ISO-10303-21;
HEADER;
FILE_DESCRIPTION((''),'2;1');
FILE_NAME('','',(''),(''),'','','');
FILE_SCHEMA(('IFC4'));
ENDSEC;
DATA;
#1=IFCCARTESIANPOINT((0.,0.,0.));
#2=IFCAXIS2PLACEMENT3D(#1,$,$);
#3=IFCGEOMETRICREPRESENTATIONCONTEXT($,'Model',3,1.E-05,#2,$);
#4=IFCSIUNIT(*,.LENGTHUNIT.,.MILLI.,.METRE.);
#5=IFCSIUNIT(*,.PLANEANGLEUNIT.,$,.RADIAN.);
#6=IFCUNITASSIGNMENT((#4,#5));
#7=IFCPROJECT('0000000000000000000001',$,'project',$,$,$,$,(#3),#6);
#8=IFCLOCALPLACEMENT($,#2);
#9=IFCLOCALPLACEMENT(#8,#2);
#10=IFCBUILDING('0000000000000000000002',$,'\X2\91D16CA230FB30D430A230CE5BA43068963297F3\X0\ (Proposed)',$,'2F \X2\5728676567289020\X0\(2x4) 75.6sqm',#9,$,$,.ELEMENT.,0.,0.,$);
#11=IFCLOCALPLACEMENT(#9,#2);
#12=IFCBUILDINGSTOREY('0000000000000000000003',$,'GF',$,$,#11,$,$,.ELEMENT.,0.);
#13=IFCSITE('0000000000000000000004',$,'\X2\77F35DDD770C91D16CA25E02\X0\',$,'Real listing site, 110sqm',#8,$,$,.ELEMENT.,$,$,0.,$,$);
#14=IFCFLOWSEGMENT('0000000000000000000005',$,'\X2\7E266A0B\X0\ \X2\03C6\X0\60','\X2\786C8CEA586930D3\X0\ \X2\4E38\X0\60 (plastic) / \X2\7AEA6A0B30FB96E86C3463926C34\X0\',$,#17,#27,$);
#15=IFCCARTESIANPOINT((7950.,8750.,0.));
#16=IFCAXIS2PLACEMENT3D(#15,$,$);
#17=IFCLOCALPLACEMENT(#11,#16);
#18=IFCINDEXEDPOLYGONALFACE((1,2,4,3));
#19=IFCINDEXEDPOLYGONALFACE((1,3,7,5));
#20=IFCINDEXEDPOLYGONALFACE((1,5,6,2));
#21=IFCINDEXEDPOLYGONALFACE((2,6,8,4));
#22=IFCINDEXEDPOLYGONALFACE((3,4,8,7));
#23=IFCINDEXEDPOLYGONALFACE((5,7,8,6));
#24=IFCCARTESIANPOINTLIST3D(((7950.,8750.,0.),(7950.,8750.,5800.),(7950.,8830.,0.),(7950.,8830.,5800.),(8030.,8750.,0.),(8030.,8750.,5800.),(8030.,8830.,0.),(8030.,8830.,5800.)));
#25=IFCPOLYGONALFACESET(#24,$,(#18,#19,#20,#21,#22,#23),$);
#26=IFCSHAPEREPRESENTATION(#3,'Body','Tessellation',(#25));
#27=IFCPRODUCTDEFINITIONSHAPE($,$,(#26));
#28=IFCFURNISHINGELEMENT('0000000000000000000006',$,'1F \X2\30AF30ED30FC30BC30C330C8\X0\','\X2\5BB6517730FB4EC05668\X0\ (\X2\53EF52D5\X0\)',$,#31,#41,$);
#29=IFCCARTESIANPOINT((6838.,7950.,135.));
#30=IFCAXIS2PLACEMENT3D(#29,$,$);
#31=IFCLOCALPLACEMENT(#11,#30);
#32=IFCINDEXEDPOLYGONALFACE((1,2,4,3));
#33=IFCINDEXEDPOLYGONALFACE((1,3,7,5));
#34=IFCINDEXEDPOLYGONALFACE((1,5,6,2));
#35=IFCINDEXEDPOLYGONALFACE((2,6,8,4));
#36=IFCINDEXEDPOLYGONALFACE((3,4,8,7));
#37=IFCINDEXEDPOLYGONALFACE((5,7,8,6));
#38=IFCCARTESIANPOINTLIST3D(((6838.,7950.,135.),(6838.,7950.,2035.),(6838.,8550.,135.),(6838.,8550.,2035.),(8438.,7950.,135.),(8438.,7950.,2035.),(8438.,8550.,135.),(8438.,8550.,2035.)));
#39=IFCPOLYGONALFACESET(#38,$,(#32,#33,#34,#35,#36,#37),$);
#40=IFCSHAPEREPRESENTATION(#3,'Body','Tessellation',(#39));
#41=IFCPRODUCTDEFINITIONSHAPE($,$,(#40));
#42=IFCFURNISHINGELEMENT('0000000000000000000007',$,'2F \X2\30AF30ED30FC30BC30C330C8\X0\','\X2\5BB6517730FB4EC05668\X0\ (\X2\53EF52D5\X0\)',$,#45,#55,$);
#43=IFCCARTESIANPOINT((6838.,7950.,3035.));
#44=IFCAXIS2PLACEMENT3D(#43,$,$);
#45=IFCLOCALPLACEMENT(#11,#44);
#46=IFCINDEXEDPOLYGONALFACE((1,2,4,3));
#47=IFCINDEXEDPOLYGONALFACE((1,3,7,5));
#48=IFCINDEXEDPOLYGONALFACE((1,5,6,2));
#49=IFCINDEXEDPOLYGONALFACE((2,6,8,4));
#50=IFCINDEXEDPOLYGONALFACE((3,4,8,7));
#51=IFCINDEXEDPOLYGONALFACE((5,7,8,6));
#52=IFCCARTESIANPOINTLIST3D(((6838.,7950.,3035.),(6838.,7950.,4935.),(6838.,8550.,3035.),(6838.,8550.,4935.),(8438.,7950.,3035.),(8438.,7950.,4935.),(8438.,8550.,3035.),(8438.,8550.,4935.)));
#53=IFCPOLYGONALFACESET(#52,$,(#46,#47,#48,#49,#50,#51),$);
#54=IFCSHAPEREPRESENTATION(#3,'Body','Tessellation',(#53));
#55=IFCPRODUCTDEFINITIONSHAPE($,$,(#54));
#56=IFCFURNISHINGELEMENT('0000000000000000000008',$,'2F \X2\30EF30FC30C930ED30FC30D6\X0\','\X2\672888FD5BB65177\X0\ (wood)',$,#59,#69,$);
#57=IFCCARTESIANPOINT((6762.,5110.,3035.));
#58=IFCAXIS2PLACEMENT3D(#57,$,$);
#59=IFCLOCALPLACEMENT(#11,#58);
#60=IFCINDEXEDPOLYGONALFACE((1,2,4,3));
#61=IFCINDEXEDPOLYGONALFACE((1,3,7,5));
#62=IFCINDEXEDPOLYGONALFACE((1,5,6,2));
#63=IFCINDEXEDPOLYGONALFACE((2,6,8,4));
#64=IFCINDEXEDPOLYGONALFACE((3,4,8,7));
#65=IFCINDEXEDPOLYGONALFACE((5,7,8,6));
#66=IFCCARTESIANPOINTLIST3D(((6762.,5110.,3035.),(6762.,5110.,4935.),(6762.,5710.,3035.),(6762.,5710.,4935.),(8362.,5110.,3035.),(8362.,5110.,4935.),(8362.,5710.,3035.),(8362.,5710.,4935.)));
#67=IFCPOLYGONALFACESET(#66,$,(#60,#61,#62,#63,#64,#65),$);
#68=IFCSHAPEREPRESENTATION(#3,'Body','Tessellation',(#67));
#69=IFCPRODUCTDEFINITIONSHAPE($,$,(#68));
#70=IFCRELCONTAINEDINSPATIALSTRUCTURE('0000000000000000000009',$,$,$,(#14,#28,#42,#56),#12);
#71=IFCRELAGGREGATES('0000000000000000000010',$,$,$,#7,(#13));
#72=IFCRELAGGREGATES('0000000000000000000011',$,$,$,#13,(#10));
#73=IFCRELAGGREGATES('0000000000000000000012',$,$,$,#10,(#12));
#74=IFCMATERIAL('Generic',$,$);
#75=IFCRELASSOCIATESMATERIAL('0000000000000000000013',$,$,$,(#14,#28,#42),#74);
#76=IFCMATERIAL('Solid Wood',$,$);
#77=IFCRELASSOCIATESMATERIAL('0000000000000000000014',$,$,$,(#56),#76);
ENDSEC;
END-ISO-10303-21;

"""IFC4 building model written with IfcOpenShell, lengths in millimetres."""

from ifc_helpers import new_model, si_unit, frame, frame_2d, origin, place, context, project, spatial, rectangle, extrude, material, element, save


model = new_model("IFC4")

# Units and contexts
model_context = context("Model", 3, precision=1e-05, world=origin())
ifc_project = project(units=[si_unit("LENGTHUNIT", "METRE", prefix="MILLI"), si_unit("PLANEANGLEUNIT", "RADIAN")], contexts=[model_context])

# Site, building, storey
site_placement = place(None, origin())
site = spatial("IfcSite", under=ifc_project, at=site_placement, Name="石川県金沢市", ObjectType="Real listing site, 110sqm", CompositionType="ELEMENT", RefElevation=0.0)
building_placement = place(site_placement, origin())
building = spatial("IfcBuilding", under=site, at=building_placement, Name="金沢・ピアノ室と防音 (Proposed)", ObjectType="2F 在来木造(2x4) 75.6sqm", CompositionType="ELEMENT", ElevationOfRefHeight=0.0, ElevationOfTerrain=0.0)
storey_placement = place(building_placement, origin())
storey = spatial("IfcBuildingStorey", under=building, at=storey_placement, Name="GF", CompositionType="ELEMENT", Elevation=0.0)

# Shared definitions
ifc_material_1 = material(Name="Solid Wood")

# Shared definitions
ifc_material_2 = material(Name="Generic")

# Flow segment
flow_segment_placement = place(storey_placement, frame((7950.0, 8750.0, 0.0)))
element("IfcFlowSegment", 1, at=flow_segment_placement, inside=storey, material=ifc_material_2, Name="縦樋 φ60", Description="硬質塩ビ 丸60 (plastic) / 竪樋・雨水排水", context=model_context, shape_type="SweptSolid", body=[
    extrude(rectangle(XDim=80.0, YDim=80.0, at=frame_2d((40.0, 40.0))), frame((7950.0, 8750.0, 0.0)), (0.0, 0.0, 1.0), 5800.0),
])

# Furnishing elements
furnishing_1_placement = place(storey_placement, frame((6838.0, 7950.0, 135.0)))
element("IfcFurnishingElement", 2, at=furnishing_1_placement, inside=storey, material=ifc_material_2, Name="1F クローゼット", Description="家具・什器 (可動)", context=model_context, shape_type="SweptSolid", body=[
    extrude(rectangle(XDim=1600.0, YDim=600.0, at=frame_2d((800.0, 300.0))), frame((6838.0, 7950.0, 135.0)), (0.0, 0.0, 1.0), 1900.0),
])
furnishing_2_placement = place(storey_placement, frame((6838.0, 7950.0, 3035.0)))
element("IfcFurnishingElement", 3, at=furnishing_2_placement, inside=storey, material=ifc_material_2, Name="2F クローゼット", Description="家具・什器 (可動)", context=model_context, shape_type="SweptSolid", body=[
    extrude(rectangle(XDim=1600.0, YDim=600.0, at=frame_2d((800.0, 300.0))), frame((6838.0, 7950.0, 3035.0)), (0.0, 0.0, 1.0), 1900.0),
])
furnishing_3_placement = place(storey_placement, frame((6762.0, 5110.0, 3035.0)))
element("IfcFurnishingElement", 4, at=furnishing_3_placement, inside=storey, material=ifc_material_1, Name="2F ワードローブ", Description="木製家具 (wood)", context=model_context, shape_type="SweptSolid", body=[
    extrude(rectangle(XDim=1600.0, YDim=600.0, at=frame_2d((800.0, 300.0))), frame((6762.0, 5110.0, 3035.0)), (0.0, 0.0, 1.0), 1900.0),
])

save(model, "model.ifc")
